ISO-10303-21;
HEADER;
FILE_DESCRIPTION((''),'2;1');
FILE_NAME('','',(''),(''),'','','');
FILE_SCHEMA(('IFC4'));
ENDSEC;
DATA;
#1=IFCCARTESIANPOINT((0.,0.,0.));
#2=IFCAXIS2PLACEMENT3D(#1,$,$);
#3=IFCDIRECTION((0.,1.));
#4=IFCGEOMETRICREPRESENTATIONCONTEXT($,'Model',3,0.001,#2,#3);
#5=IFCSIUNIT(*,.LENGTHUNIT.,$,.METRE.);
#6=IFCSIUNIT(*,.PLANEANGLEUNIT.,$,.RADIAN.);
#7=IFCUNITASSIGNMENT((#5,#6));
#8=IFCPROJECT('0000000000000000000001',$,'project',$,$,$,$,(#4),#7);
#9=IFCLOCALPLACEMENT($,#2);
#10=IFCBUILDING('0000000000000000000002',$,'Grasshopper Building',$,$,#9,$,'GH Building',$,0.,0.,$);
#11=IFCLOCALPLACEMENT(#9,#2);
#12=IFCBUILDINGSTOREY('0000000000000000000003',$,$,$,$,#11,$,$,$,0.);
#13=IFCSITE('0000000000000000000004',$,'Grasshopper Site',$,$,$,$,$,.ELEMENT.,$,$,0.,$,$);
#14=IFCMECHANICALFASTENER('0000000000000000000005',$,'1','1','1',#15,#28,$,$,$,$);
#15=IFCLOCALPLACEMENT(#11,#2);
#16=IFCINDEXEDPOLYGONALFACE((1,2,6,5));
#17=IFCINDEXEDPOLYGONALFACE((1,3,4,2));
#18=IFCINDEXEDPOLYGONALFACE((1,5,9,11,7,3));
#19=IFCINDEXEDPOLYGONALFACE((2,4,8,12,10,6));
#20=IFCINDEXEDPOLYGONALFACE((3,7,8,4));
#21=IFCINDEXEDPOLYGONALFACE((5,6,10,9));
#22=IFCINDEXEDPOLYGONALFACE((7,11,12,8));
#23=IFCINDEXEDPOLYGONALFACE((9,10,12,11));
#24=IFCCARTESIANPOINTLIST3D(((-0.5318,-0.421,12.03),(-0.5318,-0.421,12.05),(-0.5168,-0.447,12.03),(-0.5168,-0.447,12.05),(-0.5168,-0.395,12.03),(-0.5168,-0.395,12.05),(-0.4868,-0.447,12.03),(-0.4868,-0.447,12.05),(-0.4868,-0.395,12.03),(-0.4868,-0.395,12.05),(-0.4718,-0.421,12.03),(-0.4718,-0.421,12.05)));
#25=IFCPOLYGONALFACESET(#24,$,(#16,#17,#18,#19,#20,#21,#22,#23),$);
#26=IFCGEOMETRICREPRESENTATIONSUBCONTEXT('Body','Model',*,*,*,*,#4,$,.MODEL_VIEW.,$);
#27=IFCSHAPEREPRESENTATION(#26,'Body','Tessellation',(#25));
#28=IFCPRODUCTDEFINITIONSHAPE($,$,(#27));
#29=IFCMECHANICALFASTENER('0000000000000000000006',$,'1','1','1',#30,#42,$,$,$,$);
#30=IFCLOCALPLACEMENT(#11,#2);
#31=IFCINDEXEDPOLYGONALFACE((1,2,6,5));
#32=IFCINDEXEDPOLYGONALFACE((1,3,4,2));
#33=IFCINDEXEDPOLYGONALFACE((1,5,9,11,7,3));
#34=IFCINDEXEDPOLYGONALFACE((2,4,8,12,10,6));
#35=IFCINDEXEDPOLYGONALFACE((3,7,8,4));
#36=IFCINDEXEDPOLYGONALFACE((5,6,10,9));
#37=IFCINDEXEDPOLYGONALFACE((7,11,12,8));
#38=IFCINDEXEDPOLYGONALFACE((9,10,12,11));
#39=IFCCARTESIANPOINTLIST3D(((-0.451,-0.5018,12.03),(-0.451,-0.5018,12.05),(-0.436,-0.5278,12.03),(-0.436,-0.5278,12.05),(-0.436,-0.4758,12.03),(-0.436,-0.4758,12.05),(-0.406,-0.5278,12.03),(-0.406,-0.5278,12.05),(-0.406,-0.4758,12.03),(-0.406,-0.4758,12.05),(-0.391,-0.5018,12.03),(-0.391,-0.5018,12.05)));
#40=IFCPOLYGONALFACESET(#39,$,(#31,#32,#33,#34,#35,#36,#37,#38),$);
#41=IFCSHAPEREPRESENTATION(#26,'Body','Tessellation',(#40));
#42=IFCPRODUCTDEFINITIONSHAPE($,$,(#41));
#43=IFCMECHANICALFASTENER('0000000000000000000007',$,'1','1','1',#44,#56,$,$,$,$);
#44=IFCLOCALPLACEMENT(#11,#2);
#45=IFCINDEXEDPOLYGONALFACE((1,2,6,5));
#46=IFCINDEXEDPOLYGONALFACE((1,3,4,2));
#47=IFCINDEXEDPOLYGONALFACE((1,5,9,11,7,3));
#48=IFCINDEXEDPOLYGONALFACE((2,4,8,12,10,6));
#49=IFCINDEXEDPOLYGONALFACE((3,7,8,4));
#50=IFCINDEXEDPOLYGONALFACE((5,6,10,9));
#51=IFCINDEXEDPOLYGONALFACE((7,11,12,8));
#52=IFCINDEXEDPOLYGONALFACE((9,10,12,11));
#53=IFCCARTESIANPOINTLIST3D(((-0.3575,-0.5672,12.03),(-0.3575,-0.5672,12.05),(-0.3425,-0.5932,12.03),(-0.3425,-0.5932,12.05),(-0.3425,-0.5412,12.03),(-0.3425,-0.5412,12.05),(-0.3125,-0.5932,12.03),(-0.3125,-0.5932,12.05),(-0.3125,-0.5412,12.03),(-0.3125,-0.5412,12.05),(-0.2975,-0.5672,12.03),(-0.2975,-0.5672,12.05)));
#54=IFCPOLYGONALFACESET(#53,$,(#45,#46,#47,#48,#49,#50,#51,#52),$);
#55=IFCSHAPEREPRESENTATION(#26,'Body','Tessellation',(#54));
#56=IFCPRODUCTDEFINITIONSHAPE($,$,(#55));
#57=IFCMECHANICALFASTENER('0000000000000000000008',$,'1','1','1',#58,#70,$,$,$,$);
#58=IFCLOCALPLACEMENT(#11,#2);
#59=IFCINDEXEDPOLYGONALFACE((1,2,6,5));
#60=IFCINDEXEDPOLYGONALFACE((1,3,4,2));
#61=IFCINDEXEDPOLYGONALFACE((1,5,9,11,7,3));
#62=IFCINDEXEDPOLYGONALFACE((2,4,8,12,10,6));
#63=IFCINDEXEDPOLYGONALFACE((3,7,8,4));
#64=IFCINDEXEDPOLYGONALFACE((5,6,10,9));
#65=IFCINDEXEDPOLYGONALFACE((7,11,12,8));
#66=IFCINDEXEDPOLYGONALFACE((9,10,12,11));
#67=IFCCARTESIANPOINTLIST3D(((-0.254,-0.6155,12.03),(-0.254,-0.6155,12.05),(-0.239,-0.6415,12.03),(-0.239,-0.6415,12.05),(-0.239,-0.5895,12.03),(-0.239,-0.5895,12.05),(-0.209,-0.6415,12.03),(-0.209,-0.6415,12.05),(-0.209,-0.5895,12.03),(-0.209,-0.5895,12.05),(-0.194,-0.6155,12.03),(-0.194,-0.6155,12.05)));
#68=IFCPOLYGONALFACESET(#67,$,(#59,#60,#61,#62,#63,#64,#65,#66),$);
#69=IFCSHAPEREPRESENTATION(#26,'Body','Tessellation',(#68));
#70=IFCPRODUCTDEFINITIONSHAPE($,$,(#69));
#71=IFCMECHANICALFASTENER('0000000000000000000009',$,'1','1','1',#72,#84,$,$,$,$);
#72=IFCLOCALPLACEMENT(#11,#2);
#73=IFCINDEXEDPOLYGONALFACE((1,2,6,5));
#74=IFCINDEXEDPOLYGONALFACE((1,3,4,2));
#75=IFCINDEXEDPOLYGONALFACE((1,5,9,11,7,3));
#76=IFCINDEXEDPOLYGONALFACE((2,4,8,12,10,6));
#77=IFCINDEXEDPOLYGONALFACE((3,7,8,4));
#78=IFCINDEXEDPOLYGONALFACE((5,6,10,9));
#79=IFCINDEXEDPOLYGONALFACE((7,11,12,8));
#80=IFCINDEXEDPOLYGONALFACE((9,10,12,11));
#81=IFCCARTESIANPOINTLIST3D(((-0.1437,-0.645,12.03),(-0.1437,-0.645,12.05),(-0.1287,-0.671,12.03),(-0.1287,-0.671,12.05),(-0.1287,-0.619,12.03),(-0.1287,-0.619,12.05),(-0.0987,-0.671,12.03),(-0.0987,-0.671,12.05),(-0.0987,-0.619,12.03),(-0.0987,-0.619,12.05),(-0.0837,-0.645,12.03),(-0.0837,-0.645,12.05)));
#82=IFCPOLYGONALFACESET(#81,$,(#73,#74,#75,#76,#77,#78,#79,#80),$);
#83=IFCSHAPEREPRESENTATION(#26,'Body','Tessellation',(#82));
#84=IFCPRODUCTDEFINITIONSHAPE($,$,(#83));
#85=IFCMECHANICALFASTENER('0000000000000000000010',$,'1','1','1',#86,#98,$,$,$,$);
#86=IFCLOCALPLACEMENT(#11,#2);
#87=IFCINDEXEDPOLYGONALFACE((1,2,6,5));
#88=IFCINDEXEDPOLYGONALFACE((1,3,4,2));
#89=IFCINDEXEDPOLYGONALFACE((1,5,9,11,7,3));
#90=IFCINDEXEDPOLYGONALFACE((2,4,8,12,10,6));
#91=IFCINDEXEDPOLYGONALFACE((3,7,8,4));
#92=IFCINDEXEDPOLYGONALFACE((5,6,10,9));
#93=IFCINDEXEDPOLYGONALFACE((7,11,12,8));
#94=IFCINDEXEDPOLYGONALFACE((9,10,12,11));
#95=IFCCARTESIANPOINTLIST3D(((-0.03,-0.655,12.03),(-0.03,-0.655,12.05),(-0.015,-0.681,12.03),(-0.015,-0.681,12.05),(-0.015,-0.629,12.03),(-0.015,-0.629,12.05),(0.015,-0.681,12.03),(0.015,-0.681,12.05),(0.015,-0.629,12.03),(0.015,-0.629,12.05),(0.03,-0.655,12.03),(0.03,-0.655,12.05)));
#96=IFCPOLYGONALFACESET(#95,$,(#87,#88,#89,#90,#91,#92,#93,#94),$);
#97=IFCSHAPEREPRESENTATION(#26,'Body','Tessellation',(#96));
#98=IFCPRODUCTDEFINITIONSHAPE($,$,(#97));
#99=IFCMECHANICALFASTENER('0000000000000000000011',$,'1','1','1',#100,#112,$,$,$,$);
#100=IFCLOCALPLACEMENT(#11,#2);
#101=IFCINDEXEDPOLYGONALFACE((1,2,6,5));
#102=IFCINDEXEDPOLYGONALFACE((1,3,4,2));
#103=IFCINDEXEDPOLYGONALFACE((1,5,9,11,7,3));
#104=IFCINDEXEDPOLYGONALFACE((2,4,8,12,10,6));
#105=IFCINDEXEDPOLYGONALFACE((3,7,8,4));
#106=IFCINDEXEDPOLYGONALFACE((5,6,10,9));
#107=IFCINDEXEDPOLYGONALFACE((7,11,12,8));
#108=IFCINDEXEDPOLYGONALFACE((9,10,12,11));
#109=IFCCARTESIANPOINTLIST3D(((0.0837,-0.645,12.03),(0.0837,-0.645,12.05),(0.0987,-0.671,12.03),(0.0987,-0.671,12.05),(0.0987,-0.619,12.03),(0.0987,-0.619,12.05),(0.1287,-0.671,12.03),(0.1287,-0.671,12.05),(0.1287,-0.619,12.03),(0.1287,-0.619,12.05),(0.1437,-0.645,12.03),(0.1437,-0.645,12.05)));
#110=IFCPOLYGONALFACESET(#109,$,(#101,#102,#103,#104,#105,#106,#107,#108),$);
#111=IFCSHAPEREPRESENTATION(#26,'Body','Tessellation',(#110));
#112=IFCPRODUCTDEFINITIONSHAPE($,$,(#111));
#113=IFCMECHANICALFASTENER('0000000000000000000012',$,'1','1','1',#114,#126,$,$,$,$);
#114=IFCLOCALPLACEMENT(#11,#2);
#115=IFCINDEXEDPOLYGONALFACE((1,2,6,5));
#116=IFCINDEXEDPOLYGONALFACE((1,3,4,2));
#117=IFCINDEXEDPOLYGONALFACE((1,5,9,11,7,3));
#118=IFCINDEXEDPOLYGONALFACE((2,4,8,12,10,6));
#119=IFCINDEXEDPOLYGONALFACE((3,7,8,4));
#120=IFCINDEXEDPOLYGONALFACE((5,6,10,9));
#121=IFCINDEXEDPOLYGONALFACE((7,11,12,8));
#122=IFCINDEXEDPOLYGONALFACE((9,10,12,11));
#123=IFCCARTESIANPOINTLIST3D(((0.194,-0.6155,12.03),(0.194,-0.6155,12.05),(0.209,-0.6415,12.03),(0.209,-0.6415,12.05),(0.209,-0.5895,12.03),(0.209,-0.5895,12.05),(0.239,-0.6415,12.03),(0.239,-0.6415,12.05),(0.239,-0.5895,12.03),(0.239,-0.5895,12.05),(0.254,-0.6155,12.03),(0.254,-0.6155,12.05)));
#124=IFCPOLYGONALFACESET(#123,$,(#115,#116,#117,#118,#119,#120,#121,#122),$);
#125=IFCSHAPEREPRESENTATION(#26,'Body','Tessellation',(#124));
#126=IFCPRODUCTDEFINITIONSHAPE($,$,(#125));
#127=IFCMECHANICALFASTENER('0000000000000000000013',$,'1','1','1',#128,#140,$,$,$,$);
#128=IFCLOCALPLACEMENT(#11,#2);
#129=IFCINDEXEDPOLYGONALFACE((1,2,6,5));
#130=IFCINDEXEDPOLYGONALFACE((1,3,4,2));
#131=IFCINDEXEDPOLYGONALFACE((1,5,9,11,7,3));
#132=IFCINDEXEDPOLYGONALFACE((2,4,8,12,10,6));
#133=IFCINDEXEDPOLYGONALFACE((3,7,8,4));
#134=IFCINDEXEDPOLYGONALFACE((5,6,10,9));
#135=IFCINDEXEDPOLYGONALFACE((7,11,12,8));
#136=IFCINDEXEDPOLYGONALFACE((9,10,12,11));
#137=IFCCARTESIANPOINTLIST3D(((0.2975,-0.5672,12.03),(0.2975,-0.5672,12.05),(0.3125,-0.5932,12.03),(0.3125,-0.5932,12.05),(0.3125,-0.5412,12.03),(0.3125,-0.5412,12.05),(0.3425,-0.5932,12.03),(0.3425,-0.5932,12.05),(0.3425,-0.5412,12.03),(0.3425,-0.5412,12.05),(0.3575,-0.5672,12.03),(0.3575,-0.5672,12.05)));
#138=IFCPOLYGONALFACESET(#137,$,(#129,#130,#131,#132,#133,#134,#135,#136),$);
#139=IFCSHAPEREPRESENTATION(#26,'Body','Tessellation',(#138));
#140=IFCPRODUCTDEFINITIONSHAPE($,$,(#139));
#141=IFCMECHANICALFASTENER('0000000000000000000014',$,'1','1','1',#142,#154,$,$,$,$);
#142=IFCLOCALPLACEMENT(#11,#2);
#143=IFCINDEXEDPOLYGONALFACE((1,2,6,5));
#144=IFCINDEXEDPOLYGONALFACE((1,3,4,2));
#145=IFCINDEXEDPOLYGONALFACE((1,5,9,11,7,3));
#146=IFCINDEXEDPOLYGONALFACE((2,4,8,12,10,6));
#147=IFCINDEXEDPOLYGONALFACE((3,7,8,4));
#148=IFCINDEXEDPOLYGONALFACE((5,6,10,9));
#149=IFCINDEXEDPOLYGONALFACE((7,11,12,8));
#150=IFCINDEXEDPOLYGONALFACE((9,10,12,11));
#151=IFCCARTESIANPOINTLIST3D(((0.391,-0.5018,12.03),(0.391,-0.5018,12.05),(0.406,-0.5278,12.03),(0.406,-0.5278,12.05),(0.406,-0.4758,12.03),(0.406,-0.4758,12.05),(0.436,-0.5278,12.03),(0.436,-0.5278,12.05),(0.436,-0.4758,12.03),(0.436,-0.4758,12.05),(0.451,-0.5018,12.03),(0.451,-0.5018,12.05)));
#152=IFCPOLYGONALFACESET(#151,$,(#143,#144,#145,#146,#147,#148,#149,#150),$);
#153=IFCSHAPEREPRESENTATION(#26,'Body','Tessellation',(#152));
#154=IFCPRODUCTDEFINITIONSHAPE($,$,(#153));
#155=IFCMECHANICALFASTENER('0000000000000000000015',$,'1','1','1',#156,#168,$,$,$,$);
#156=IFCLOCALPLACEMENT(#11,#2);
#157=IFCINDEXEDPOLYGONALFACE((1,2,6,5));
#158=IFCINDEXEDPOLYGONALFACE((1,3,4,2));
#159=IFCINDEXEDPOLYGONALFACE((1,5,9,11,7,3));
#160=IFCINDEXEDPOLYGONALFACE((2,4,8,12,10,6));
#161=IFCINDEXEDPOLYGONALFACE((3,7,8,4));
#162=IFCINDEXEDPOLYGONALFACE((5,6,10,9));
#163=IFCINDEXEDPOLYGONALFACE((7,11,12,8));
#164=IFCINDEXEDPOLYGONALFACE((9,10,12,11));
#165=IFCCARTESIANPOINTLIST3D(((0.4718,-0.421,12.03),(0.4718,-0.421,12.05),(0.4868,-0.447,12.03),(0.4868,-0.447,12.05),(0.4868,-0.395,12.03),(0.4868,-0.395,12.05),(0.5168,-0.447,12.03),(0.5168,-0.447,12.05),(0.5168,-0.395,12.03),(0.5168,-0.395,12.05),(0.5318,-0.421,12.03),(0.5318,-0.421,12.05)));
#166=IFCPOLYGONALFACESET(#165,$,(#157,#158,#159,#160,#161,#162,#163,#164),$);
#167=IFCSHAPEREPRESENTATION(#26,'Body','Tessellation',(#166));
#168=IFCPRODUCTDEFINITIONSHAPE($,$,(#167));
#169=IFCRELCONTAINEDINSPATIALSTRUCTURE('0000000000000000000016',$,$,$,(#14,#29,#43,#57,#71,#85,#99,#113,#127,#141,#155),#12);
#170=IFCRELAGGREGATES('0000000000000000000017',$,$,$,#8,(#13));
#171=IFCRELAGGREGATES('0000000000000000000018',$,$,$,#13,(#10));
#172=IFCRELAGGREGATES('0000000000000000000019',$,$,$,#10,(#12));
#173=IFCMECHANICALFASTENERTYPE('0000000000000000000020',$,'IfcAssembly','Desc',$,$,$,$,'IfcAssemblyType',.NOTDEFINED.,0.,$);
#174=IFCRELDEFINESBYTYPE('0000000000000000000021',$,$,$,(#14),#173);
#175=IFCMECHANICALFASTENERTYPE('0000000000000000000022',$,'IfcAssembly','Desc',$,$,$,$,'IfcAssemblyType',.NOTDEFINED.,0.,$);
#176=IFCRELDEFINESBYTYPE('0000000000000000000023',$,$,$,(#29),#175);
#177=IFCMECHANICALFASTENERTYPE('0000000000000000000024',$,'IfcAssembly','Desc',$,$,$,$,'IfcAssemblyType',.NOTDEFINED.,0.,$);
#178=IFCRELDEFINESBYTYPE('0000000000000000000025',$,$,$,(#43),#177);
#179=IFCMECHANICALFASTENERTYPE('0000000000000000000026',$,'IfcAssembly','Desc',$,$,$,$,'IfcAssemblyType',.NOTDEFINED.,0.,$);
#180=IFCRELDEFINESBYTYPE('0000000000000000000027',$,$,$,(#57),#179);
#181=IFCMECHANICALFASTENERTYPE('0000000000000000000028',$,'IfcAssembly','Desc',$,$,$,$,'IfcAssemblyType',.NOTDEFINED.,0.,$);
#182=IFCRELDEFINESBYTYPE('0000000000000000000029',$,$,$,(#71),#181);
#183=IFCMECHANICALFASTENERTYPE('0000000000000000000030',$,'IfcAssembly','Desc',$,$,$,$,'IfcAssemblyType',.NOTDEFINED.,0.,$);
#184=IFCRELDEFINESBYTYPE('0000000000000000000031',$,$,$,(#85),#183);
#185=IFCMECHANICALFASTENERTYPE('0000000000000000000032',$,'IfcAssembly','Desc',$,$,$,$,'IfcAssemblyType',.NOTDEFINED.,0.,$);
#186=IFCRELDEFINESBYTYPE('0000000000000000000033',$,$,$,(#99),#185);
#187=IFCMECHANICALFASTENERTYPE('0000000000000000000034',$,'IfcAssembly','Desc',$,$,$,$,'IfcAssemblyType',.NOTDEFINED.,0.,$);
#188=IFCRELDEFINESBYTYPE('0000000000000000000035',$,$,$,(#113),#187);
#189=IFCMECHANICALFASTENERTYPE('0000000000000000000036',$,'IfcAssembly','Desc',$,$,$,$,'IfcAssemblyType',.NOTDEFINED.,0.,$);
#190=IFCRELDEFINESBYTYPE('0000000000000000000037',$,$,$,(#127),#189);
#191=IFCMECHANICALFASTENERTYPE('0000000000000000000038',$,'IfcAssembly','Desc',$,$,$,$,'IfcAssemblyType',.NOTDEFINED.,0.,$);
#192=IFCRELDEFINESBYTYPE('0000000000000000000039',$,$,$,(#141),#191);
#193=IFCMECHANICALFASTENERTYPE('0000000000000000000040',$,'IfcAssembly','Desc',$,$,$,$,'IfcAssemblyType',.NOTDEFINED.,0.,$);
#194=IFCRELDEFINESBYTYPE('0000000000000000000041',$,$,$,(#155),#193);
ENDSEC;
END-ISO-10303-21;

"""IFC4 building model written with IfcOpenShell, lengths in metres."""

from ifc_helpers import new_model, si_unit, direction, frame, origin, place, context, subcontext, project, spatial, indexed_curve, outline, extrude, source, transform, mapped, type_object, type_shapes, element, save


model = new_model("IFC4")

# Units and contexts
model_context = context("Model", 3, precision=0.001, world=origin(), true_north=direction((0.0, 1.0)))
body_context = subcontext(model_context, "Body", "Model", "MODEL_VIEW")
ifc_project = project(units=[si_unit("LENGTHUNIT", "METRE"), si_unit("PLANEANGLEUNIT", "RADIAN")], contexts=[model_context])

# Site, building, storey
site = spatial("IfcSite", under=ifc_project, Name="Grasshopper Site", CompositionType="ELEMENT", RefElevation=0.0)
building_placement = place(None, origin())
building = spatial("IfcBuilding", under=site, at=building_placement, Name="Grasshopper Building", LongName="GH Building", ElevationOfRefHeight=0.0, ElevationOfTerrain=0.0)
storey_placement = place(building_placement, origin())
storey = spatial("IfcBuildingStorey", under=building, at=storey_placement, Elevation=0.0)

# Mechanical fasteners
mechanical_fastener_type_1 = type_object("IfcMechanicalFastenerType", Name="IfcAssembly", Description="Desc", ElementType="IfcAssemblyType", NominalDiameter=0.0)
shared_shape_1 = source(origin(), body_context, "Body", "SweptSolid", [
    extrude(outline(indexed_curve([(0.03, 0.0), (0.015, 0.026), (-0.015, 0.026), (-0.03, 0.0), (-0.015, -0.026), (0.015, -0.026), (0.03, 0.0)])), frame((-0.5018, -0.421, 12.03)), (0.0, 0.0, 1.0), 0.02),
])
type_shapes(mechanical_fastener_type_1, [shared_shape_1])
mechanical_fastener_1_placement = place(storey_placement, origin())
element("IfcMechanicalFastener", 1, at=mechanical_fastener_1_placement, inside=storey, type_object=mechanical_fastener_type_1, Name="1", Description="1", ObjectType="1", context=body_context, shape_type="MappedRepresentation", body=[
    mapped(shared_shape_1, transform((0.0, 0.0, 0.0), scale=1.0)),
])
mechanical_fastener_type_2 = type_object("IfcMechanicalFastenerType", Name="IfcAssembly", Description="Desc", ElementType="IfcAssemblyType", NominalDiameter=0.0)
shared_shape_2 = source(origin(), body_context, "Body", "SweptSolid", [
    extrude(outline(indexed_curve([(0.03, 0.0), (0.015, 0.026), (-0.015, 0.026), (-0.03, 0.0), (-0.015, -0.026), (0.015, -0.026), (0.03, 0.0)])), frame((-0.421, -0.5018, 12.03)), (0.0, 0.0, 1.0), 0.02),
])
type_shapes(mechanical_fastener_type_2, [shared_shape_2])
mechanical_fastener_2_placement = place(storey_placement, origin())
element("IfcMechanicalFastener", 2, at=mechanical_fastener_2_placement, inside=storey, type_object=mechanical_fastener_type_2, Name="1", Description="1", ObjectType="1", context=body_context, shape_type="MappedRepresentation", body=[
    mapped(shared_shape_2, transform((0.0, 0.0, 0.0), scale=1.0)),
])
mechanical_fastener_type_3 = type_object("IfcMechanicalFastenerType", Name="IfcAssembly", Description="Desc", ElementType="IfcAssemblyType", NominalDiameter=0.0)
shared_shape_3 = source(origin(), body_context, "Body", "SweptSolid", [
    extrude(outline(indexed_curve([(0.03, 0.0), (0.015, 0.026), (-0.015, 0.026), (-0.03, 0.0), (-0.015, -0.026), (0.015, -0.026), (0.03, 0.0)])), frame((-0.3275, -0.5672, 12.03)), (0.0, 0.0, 1.0), 0.02),
])
type_shapes(mechanical_fastener_type_3, [shared_shape_3])
mechanical_fastener_3_placement = place(storey_placement, origin())
element("IfcMechanicalFastener", 3, at=mechanical_fastener_3_placement, inside=storey, type_object=mechanical_fastener_type_3, Name="1", Description="1", ObjectType="1", context=body_context, shape_type="MappedRepresentation", body=[
    mapped(shared_shape_3, transform((0.0, 0.0, 0.0), scale=1.0)),
])
mechanical_fastener_type_4 = type_object("IfcMechanicalFastenerType", Name="IfcAssembly", Description="Desc", ElementType="IfcAssemblyType", NominalDiameter=0.0)
shared_shape_4 = source(origin(), body_context, "Body", "SweptSolid", [
    extrude(outline(indexed_curve([(0.03, 0.0), (0.015, 0.026), (-0.015, 0.026), (-0.03, 0.0), (-0.015, -0.026), (0.015, -0.026), (0.03, 0.0)])), frame((-0.224, -0.6155, 12.03)), (0.0, 0.0, 1.0), 0.02),
])
type_shapes(mechanical_fastener_type_4, [shared_shape_4])
mechanical_fastener_4_placement = place(storey_placement, origin())
element("IfcMechanicalFastener", 4, at=mechanical_fastener_4_placement, inside=storey, type_object=mechanical_fastener_type_4, Name="1", Description="1", ObjectType="1", context=body_context, shape_type="MappedRepresentation", body=[
    mapped(shared_shape_4, transform((0.0, 0.0, 0.0), scale=1.0)),
])
mechanical_fastener_type_5 = type_object("IfcMechanicalFastenerType", Name="IfcAssembly", Description="Desc", ElementType="IfcAssemblyType", NominalDiameter=0.0)
shared_shape_5 = source(origin(), body_context, "Body", "SweptSolid", [
    extrude(outline(indexed_curve([(0.03, 0.0), (0.015, 0.026), (-0.015, 0.026), (-0.03, 0.0), (-0.015, -0.026), (0.015, -0.026), (0.03, 0.0)])), frame((-0.1137, -0.645, 12.03)), (0.0, 0.0, 1.0), 0.02),
])
type_shapes(mechanical_fastener_type_5, [shared_shape_5])
mechanical_fastener_5_placement = place(storey_placement, origin())
element("IfcMechanicalFastener", 5, at=mechanical_fastener_5_placement, inside=storey, type_object=mechanical_fastener_type_5, Name="1", Description="1", ObjectType="1", context=body_context, shape_type="MappedRepresentation", body=[
    mapped(shared_shape_5, transform((0.0, 0.0, 0.0), scale=1.0)),
])
mechanical_fastener_type_6 = type_object("IfcMechanicalFastenerType", Name="IfcAssembly", Description="Desc", ElementType="IfcAssemblyType", NominalDiameter=0.0)
shared_shape_6 = source(origin(), body_context, "Body", "SweptSolid", [
    extrude(outline(indexed_curve([(0.03, 0.0), (0.015, 0.026), (-0.015, 0.026), (-0.03, 0.0), (-0.015, -0.026), (0.015, -0.026), (0.03, 0.0)])), frame((0.0, -0.655, 12.03)), (0.0, 0.0, 1.0), 0.02),
])
type_shapes(mechanical_fastener_type_6, [shared_shape_6])
mechanical_fastener_6_placement = place(storey_placement, origin())
element("IfcMechanicalFastener", 6, at=mechanical_fastener_6_placement, inside=storey, type_object=mechanical_fastener_type_6, Name="1", Description="1", ObjectType="1", context=body_context, shape_type="MappedRepresentation", body=[
    mapped(shared_shape_6, transform((0.0, 0.0, 0.0), scale=1.0)),
])
mechanical_fastener_type_7 = type_object("IfcMechanicalFastenerType", Name="IfcAssembly", Description="Desc", ElementType="IfcAssemblyType", NominalDiameter=0.0)
shared_shape_7 = source(origin(), body_context, "Body", "SweptSolid", [
    extrude(outline(indexed_curve([(0.03, 0.0), (0.015, 0.026), (-0.015, 0.026), (-0.03, 0.0), (-0.015, -0.026), (0.015, -0.026), (0.03, 0.0)])), frame((0.1137, -0.645, 12.03)), (0.0, 0.0, 1.0), 0.02),
])
type_shapes(mechanical_fastener_type_7, [shared_shape_7])
mechanical_fastener_7_placement = place(storey_placement, origin())
element("IfcMechanicalFastener", 7, at=mechanical_fastener_7_placement, inside=storey, type_object=mechanical_fastener_type_7, Name="1", Description="1", ObjectType="1", context=body_context, shape_type="MappedRepresentation", body=[
    mapped(shared_shape_7, transform((0.0, 0.0, 0.0), scale=1.0)),
])
mechanical_fastener_type_8 = type_object("IfcMechanicalFastenerType", Name="IfcAssembly", Description="Desc", ElementType="IfcAssemblyType", NominalDiameter=0.0)
shared_shape_8 = source(origin(), body_context, "Body", "SweptSolid", [
    extrude(outline(indexed_curve([(0.03, 0.0), (0.015, 0.026), (-0.015, 0.026), (-0.03, 0.0), (-0.015, -0.026), (0.015, -0.026), (0.03, 0.0)])), frame((0.224, -0.6155, 12.03)), (0.0, 0.0, 1.0), 0.02),
])
type_shapes(mechanical_fastener_type_8, [shared_shape_8])
mechanical_fastener_8_placement = place(storey_placement, origin())
element("IfcMechanicalFastener", 8, at=mechanical_fastener_8_placement, inside=storey, type_object=mechanical_fastener_type_8, Name="1", Description="1", ObjectType="1", context=body_context, shape_type="MappedRepresentation", body=[
    mapped(shared_shape_8, transform((0.0, 0.0, 0.0), scale=1.0)),
])
mechanical_fastener_type_9 = type_object("IfcMechanicalFastenerType", Name="IfcAssembly", Description="Desc", ElementType="IfcAssemblyType", NominalDiameter=0.0)
shared_shape_9 = source(origin(), body_context, "Body", "SweptSolid", [
    extrude(outline(indexed_curve([(0.03, 0.0), (0.015, 0.026), (-0.015, 0.026), (-0.03, 0.0), (-0.015, -0.026), (0.015, -0.026), (0.03, 0.0)])), frame((0.3275, -0.5672, 12.03)), (0.0, 0.0, 1.0), 0.02),
])
type_shapes(mechanical_fastener_type_9, [shared_shape_9])
mechanical_fastener_9_placement = place(storey_placement, origin())
element("IfcMechanicalFastener", 9, at=mechanical_fastener_9_placement, inside=storey, type_object=mechanical_fastener_type_9, Name="1", Description="1", ObjectType="1", context=body_context, shape_type="MappedRepresentation", body=[
    mapped(shared_shape_9, transform((0.0, 0.0, 0.0), scale=1.0)),
])
mechanical_fastener_type_10 = type_object("IfcMechanicalFastenerType", Name="IfcAssembly", Description="Desc", ElementType="IfcAssemblyType", NominalDiameter=0.0)
shared_shape_10 = source(origin(), body_context, "Body", "SweptSolid", [
    extrude(outline(indexed_curve([(0.03, 0.0), (0.015, 0.026), (-0.015, 0.026), (-0.03, 0.0), (-0.015, -0.026), (0.015, -0.026), (0.03, 0.0)])), frame((0.421, -0.5018, 12.03)), (0.0, 0.0, 1.0), 0.02),
])
type_shapes(mechanical_fastener_type_10, [shared_shape_10])
mechanical_fastener_10_placement = place(storey_placement, origin())
element("IfcMechanicalFastener", 10, at=mechanical_fastener_10_placement, inside=storey, type_object=mechanical_fastener_type_10, Name="1", Description="1", ObjectType="1", context=body_context, shape_type="MappedRepresentation", body=[
    mapped(shared_shape_10, transform((0.0, 0.0, 0.0), scale=1.0)),
])
mechanical_fastener_type_11 = type_object("IfcMechanicalFastenerType", Name="IfcAssembly", Description="Desc", ElementType="IfcAssemblyType", NominalDiameter=0.0)
shared_shape_11 = source(origin(), body_context, "Body", "SweptSolid", [
    extrude(outline(indexed_curve([(0.03, 0.0), (0.015, 0.026), (-0.015, 0.026), (-0.03, 0.0), (-0.015, -0.026), (0.015, -0.026), (0.03, 0.0)])), frame((0.5018, -0.421, 12.03)), (0.0, 0.0, 1.0), 0.02),
])
type_shapes(mechanical_fastener_type_11, [shared_shape_11])
mechanical_fastener_11_placement = place(storey_placement, origin())
element("IfcMechanicalFastener", 11, at=mechanical_fastener_11_placement, inside=storey, type_object=mechanical_fastener_type_11, Name="1", Description="1", ObjectType="1", context=body_context, shape_type="MappedRepresentation", body=[
    mapped(shared_shape_11, transform((0.0, 0.0, 0.0), scale=1.0)),
])

save(model, "model.ifc")
